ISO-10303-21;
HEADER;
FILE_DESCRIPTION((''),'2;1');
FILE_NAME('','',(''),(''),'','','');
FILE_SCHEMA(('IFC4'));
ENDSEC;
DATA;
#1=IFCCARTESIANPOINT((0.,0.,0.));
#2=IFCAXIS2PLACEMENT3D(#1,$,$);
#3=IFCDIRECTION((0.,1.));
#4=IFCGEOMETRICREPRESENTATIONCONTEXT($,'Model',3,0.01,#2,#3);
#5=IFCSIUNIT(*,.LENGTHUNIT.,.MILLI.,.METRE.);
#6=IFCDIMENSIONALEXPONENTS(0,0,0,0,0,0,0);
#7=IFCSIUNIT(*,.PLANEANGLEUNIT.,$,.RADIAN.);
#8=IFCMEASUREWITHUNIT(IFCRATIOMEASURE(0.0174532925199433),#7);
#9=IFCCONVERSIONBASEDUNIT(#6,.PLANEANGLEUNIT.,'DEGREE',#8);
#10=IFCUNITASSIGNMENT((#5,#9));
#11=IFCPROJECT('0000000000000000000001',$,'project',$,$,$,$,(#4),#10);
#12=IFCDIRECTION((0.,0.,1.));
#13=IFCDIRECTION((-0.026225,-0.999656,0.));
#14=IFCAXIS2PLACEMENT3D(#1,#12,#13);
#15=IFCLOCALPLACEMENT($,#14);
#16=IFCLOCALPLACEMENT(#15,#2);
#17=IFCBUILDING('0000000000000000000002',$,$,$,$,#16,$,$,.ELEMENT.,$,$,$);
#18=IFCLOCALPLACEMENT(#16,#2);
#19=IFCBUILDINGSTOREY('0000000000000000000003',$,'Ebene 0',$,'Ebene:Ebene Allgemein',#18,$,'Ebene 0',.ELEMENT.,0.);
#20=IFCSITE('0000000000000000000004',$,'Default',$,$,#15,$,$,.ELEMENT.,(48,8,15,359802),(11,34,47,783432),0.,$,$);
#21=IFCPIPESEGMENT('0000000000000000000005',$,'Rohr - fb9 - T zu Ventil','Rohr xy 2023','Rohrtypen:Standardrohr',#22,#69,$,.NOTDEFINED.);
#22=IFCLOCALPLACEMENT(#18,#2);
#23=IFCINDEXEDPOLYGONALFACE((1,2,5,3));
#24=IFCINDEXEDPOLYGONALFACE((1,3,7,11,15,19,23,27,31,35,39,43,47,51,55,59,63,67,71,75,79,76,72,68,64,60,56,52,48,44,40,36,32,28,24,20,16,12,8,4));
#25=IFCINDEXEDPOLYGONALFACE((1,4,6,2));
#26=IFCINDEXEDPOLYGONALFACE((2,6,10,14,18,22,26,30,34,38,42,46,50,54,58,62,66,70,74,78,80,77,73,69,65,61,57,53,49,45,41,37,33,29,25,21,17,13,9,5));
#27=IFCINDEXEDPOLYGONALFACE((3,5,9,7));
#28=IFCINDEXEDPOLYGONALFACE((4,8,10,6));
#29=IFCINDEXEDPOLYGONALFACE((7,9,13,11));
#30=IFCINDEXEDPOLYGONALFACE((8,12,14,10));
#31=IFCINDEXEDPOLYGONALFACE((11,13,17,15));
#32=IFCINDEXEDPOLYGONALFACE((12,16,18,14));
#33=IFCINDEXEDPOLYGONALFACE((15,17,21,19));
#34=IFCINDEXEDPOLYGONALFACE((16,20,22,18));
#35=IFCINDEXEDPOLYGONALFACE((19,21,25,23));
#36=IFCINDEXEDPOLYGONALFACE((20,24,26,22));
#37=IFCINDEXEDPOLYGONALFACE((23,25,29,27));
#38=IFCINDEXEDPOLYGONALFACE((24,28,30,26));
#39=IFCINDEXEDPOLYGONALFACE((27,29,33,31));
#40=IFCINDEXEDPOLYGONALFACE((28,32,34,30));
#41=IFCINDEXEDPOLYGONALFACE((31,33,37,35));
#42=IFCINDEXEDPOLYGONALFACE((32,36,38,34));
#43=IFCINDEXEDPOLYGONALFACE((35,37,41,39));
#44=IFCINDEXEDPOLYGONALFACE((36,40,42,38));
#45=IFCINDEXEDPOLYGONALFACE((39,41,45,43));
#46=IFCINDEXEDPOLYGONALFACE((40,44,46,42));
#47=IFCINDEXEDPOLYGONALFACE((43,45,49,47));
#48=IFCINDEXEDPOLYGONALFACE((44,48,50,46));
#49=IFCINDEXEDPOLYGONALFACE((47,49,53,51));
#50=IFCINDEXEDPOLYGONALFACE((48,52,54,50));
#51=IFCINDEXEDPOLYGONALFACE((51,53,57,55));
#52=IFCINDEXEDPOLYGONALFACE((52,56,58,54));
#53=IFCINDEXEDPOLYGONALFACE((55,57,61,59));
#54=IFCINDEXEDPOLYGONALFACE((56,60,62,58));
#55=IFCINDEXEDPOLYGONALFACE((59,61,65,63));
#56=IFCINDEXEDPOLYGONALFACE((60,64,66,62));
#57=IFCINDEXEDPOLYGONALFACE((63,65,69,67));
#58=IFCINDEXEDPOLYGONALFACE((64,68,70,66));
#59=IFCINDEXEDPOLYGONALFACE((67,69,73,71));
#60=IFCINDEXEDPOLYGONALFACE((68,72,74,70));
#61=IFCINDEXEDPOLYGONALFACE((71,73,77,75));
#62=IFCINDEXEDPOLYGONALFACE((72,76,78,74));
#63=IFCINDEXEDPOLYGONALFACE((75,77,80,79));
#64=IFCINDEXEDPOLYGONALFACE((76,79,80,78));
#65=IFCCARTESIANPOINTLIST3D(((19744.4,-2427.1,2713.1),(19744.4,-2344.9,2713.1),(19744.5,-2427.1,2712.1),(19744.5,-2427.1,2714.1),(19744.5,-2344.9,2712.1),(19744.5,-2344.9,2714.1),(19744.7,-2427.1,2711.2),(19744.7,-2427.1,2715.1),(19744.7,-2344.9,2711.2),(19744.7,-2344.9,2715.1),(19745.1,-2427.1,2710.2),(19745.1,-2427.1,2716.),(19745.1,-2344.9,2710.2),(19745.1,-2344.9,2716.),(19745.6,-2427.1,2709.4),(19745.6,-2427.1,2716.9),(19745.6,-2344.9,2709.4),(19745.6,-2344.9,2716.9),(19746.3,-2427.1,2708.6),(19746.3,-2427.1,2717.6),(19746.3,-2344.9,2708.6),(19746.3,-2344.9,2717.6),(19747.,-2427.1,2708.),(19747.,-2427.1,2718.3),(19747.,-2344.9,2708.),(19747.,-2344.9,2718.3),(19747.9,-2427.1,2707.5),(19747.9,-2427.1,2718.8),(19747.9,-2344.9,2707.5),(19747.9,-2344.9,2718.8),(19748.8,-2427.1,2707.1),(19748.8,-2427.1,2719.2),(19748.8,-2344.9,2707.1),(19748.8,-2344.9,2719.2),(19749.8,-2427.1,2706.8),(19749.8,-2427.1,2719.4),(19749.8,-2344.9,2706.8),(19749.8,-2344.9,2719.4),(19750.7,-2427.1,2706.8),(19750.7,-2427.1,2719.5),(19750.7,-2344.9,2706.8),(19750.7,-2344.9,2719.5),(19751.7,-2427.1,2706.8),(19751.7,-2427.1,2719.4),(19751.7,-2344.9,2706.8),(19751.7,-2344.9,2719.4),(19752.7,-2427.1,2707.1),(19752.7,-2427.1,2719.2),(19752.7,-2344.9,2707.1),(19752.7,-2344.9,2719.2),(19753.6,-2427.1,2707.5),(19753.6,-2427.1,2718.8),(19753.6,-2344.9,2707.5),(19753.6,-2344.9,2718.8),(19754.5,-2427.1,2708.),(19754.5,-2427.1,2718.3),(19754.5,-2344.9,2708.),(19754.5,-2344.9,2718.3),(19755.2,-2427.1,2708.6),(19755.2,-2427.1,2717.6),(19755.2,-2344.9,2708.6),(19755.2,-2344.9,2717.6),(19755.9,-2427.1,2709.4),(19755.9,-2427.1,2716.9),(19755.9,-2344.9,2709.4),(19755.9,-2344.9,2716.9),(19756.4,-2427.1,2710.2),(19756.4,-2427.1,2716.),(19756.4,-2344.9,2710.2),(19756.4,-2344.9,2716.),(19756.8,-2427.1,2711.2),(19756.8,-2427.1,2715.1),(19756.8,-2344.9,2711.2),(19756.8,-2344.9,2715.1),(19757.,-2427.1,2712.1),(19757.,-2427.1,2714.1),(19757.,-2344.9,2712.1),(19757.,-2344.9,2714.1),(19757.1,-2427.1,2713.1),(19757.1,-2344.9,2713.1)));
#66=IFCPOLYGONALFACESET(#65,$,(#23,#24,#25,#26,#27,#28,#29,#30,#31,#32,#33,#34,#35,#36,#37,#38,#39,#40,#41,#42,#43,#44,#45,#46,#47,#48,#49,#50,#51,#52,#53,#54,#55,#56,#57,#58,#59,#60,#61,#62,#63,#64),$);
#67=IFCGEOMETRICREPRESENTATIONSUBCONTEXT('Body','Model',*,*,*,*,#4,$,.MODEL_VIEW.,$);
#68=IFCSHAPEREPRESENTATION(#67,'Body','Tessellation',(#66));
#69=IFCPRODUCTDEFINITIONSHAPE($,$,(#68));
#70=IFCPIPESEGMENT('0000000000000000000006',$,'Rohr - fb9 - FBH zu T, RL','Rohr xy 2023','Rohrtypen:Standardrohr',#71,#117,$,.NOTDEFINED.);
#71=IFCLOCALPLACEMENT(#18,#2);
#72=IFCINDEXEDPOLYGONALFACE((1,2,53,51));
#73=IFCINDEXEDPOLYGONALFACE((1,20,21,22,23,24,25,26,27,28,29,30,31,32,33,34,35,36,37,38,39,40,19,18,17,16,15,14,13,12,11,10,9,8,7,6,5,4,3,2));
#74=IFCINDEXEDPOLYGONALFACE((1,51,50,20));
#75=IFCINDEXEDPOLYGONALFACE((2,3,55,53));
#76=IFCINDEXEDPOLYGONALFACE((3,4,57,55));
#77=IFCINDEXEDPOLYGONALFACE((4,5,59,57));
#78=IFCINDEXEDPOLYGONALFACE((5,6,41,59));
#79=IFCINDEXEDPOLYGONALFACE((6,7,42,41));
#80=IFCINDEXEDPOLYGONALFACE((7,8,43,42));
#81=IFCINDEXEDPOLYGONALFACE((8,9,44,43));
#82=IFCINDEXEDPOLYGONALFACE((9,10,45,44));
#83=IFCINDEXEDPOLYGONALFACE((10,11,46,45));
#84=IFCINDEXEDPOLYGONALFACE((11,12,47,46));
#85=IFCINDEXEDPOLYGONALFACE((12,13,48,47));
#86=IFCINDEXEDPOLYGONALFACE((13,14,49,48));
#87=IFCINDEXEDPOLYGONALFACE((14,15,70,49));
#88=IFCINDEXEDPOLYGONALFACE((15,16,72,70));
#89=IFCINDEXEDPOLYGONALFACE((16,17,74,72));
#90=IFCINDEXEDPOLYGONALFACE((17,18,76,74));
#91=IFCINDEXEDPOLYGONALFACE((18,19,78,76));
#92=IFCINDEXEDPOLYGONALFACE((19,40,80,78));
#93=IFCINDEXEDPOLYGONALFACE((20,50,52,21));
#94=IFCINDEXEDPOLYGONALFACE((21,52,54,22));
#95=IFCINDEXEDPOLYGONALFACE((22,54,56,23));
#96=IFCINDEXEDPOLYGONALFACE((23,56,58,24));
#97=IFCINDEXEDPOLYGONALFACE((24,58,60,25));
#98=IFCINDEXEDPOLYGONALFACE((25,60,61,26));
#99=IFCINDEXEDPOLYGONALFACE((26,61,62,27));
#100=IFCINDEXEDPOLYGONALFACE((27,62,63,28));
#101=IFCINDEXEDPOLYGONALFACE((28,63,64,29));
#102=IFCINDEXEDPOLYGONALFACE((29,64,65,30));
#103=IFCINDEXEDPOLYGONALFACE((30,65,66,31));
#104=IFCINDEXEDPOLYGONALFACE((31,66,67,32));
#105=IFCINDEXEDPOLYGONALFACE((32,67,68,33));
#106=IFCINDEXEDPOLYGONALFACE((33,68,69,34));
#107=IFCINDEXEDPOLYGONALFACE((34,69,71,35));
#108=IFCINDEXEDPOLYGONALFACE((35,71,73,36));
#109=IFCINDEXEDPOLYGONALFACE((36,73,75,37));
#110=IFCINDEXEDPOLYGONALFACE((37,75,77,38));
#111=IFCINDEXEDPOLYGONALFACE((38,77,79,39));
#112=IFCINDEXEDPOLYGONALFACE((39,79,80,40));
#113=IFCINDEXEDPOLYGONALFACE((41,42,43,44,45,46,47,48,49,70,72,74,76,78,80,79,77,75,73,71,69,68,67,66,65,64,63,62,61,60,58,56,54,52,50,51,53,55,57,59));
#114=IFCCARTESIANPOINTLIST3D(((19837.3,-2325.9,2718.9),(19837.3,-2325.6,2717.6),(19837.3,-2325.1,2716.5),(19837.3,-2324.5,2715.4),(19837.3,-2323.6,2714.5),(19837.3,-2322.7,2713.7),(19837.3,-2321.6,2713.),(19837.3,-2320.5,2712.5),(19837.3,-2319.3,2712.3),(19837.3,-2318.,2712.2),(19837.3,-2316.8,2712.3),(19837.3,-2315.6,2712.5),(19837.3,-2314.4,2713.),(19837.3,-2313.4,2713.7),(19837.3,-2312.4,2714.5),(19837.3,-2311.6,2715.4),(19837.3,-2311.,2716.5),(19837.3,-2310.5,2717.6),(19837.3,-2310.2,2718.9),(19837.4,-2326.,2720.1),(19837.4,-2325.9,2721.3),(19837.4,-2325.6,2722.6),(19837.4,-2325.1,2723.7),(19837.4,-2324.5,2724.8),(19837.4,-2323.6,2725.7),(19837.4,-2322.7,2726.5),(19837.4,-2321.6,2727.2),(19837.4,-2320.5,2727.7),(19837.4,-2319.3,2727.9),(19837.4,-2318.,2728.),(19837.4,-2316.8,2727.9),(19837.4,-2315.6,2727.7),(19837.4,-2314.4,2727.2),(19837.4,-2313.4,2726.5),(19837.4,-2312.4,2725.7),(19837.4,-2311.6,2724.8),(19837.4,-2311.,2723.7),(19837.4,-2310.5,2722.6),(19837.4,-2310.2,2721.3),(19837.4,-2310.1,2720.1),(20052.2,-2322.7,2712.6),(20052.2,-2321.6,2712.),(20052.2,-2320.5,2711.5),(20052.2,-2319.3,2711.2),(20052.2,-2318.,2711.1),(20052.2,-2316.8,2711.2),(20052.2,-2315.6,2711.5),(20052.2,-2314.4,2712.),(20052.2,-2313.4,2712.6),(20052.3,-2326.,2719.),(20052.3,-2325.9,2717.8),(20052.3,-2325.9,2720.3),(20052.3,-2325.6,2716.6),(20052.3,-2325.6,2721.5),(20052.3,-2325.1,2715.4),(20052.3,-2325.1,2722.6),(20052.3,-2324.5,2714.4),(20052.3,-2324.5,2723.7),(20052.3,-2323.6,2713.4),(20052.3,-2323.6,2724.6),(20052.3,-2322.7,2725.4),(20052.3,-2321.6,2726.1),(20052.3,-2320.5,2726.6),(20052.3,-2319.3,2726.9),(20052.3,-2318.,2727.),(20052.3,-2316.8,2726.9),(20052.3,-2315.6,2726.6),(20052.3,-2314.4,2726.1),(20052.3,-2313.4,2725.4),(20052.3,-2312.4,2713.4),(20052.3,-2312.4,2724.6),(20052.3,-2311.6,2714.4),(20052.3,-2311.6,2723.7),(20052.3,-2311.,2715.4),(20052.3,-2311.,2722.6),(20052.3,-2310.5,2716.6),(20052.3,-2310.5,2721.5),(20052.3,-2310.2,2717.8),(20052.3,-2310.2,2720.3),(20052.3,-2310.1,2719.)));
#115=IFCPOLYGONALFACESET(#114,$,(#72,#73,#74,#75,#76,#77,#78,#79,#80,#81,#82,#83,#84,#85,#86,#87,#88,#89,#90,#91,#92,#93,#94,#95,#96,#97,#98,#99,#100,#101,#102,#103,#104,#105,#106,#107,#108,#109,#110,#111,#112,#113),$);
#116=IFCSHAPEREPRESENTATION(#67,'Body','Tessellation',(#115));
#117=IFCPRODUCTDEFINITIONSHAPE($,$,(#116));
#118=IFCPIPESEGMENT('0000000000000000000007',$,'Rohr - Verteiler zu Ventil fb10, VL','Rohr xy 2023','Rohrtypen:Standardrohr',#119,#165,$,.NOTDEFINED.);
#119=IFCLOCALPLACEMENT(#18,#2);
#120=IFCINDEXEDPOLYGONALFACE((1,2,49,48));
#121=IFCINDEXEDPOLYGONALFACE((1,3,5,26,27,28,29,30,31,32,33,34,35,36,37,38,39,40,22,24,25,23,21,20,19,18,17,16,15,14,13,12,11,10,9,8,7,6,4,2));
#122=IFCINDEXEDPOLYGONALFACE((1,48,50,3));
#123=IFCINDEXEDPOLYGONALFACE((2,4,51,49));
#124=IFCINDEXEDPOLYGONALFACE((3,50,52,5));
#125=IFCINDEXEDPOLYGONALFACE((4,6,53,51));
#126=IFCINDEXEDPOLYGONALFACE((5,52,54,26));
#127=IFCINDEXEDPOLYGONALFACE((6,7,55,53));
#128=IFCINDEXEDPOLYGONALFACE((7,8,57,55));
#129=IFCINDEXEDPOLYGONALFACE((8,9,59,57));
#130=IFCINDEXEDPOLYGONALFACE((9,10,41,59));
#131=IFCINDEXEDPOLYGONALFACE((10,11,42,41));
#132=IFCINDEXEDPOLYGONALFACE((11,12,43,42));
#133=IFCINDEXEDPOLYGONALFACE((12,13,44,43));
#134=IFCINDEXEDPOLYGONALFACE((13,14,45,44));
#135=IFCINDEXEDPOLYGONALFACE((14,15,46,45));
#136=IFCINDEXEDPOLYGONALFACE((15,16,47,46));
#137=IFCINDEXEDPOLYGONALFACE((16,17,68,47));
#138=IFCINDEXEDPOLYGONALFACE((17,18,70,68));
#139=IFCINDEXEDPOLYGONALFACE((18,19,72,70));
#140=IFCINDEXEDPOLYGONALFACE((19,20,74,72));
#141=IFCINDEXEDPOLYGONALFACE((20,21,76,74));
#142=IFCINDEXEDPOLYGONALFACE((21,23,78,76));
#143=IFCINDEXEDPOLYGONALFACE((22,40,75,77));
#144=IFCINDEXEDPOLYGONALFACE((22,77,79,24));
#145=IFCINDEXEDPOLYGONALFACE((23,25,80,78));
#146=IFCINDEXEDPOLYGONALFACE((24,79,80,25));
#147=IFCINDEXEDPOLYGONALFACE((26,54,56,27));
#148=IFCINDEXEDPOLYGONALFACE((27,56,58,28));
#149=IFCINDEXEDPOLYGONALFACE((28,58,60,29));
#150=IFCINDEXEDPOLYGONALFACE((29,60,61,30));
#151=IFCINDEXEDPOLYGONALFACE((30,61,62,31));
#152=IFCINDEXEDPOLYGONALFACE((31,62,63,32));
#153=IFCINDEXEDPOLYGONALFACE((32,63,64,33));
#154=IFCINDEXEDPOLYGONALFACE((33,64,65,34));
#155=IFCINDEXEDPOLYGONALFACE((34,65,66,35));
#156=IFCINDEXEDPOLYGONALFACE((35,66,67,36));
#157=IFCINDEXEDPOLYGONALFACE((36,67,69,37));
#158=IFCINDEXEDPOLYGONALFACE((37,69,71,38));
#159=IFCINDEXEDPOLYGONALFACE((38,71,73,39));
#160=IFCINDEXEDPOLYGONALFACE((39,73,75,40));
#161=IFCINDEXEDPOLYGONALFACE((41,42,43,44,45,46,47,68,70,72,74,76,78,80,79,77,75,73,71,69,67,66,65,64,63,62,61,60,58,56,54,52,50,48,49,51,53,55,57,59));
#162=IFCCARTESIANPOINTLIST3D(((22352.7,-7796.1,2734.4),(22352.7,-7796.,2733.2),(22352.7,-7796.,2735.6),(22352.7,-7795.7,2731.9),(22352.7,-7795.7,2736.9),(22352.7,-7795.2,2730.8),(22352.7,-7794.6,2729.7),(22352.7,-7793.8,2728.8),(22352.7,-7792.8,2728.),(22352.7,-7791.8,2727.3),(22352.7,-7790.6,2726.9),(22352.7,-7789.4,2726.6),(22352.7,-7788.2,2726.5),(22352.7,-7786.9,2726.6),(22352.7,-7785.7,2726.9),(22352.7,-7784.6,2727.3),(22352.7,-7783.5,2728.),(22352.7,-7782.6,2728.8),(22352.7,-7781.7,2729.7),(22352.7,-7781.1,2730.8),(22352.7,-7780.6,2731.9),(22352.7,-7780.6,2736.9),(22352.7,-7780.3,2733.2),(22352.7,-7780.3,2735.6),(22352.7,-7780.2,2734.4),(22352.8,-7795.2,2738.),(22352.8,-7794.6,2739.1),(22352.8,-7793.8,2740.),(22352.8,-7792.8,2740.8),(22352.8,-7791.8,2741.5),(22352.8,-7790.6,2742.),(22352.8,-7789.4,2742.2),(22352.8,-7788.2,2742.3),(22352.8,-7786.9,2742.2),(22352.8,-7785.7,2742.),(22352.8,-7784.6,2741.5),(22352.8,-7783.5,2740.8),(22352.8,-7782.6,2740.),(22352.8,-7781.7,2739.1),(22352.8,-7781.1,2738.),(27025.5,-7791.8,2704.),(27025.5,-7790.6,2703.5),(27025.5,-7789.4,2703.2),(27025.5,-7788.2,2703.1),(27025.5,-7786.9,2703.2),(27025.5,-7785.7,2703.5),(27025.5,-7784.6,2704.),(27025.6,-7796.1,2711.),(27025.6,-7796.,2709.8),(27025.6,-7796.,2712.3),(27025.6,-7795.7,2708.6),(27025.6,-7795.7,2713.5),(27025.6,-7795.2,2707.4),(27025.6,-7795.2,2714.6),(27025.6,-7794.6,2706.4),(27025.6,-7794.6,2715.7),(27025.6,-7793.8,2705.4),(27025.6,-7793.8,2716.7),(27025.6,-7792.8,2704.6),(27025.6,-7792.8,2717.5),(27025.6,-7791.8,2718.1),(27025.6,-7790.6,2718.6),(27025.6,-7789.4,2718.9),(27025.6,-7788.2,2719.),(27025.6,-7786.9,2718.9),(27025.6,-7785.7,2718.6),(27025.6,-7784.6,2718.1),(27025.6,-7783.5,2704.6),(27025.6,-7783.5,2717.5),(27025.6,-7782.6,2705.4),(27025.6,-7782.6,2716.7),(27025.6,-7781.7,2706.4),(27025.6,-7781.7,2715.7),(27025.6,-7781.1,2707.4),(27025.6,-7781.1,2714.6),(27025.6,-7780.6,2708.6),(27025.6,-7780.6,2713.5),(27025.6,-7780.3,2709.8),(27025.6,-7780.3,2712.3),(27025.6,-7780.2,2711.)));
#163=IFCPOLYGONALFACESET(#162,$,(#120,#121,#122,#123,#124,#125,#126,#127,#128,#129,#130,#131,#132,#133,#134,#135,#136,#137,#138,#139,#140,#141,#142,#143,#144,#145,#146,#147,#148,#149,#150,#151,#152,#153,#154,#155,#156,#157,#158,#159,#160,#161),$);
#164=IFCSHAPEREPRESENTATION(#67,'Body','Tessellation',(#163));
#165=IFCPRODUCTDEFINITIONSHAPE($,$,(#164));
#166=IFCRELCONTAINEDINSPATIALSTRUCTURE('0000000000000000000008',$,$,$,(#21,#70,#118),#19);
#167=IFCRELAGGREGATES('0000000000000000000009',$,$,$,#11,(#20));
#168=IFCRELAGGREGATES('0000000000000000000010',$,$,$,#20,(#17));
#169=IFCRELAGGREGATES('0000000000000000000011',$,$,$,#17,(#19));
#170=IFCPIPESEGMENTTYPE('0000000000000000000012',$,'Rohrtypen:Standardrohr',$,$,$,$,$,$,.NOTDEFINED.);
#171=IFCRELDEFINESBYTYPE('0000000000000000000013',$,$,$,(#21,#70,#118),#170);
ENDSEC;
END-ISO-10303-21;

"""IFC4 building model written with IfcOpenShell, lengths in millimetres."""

from ifc_helpers import new_model, entity, si_unit, converted_unit, direction, frame, origin, place, context, subcontext, project, spatial, indexed_curve, outline, extrude, type_object, element, save


model = new_model("IFC4")

# Units and contexts
model_context = context("Model", 3, precision=0.01, world=origin(), true_north=direction((0.0, 1.0)))
body_context = subcontext(model_context, "Body", "Model", "MODEL_VIEW")
ifc_project = project(units=[si_unit("LENGTHUNIT", "METRE", prefix="MILLI"), converted_unit("PLANEANGLEUNIT", "DEGREE", entity("IfcRatioMeasure", 0.0174532925199433), si_unit("PLANEANGLEUNIT", "RADIAN"), dimensions=[0, 0, 0, 0, 0, 0, 0])], contexts=[model_context])

# Site, building, storey
site_placement = place(None, frame((0.0, 0.0, 0.0), z_axis=(0.0, 0.0, 1.0), x_axis=(-0.026225, -0.999656, 0.0)))
site = spatial("IfcSite", under=ifc_project, at=site_placement, Name="Default", CompositionType="ELEMENT", RefLatitude=(48, 8, 15, 359802), RefLongitude=(11, 34, 47, 783432), RefElevation=0.0)
building_placement = place(site_placement, origin())
building = spatial("IfcBuilding", under=site, at=building_placement, CompositionType="ELEMENT")
storey_placement = place(building_placement, origin())
storey = spatial("IfcBuildingStorey", under=building, at=storey_placement, Name="Ebene 0", ObjectType="Ebene:Ebene Allgemein", LongName="Ebene 0", CompositionType="ELEMENT", Elevation=0.0)

# Pipe segments
pipe_segment_type = type_object("IfcPipeSegmentType", Name="Rohrtypen:Standardrohr", PredefinedType="NOTDEFINED")
pipe_segment_1_placement = place(storey_placement, origin())
element("IfcPipeSegment", 1, at=pipe_segment_1_placement, inside=storey, type_object=pipe_segment_type, Name="Rohr - fb9 - T zu Ventil", Description="Rohr xy 2023", ObjectType="Rohrtypen:Standardrohr", PredefinedType="NOTDEFINED", context=body_context, shape_type="SweptSolid", body=[
    extrude(outline(indexed_curve([(6.3, 0.0), (6.3, 1.0), (6.0, 2.0), (5.7, 2.9), (5.1, 3.7), (4.5, 4.5), (3.7, 5.1), (2.9, 5.7), (2.0, 6.0), (1.0, 6.3), (0.0, 6.4), (-1.0, 6.3), (-2.0, 6.0), (-2.9, 5.7), (-3.7, 5.1), (-4.5, 4.5), (-5.1, 3.7), (-5.7, 2.9), (-6.0, 2.0), (-6.3, 1.0), (-6.3, 0.0), (-6.3, -1.0), (-6.0, -2.0), (-5.7, -2.9), (-5.1, -3.7), (-4.5, -4.5), (-3.7, -5.1), (-2.9, -5.7), (-2.0, -6.0), (-1.0, -6.3), (0.0, -6.4), (1.0, -6.3), (2.0, -6.0), (2.9, -5.7), (3.7, -5.1), (4.5, -4.5), (5.1, -3.7), (5.7, -2.9), (6.0, -2.0), (6.3, -1.0), (6.3, 0.0)], self_intersect=False)), frame((19750.7, -2427.1, 2713.1), z_axis=(0.0, 1.0, 0.0), x_axis=(-1.0, 0.0, 0.0)), (0.0, 0.0, 1.0), 82.2),
])
pipe_segment_2_placement = place(storey_placement, origin())
element("IfcPipeSegment", 2, at=pipe_segment_2_placement, inside=storey, type_object=pipe_segment_type, Name="Rohr - fb9 - FBH zu T, RL", Description="Rohr xy 2023", ObjectType="Rohrtypen:Standardrohr", PredefinedType="NOTDEFINED", context=body_context, shape_type="SweptSolid", body=[
    extrude(outline(indexed_curve([(7.9, 0.0), (7.8, 1.2), (7.6, 2.5), (7.1, 3.6), (6.4, 4.7), (5.6, 5.6), (4.7, 6.4), (3.6, 7.1), (2.5, 7.6), (1.2, 7.8), (0.0, 7.9), (-1.2, 7.8), (-2.5, 7.6), (-3.6, 7.1), (-4.7, 6.4), (-5.6, 5.6), (-6.4, 4.7), (-7.1, 3.6), (-7.6, 2.5), (-7.8, 1.2), (-7.9, 0.0), (-7.8, -1.2), (-7.6, -2.5), (-7.1, -3.6), (-6.4, -4.7), (-5.6, -5.6), (-4.7, -6.4), (-3.6, -7.1), (-2.5, -7.6), (-1.2, -7.8), (0.0, -7.9), (1.2, -7.8), (2.5, -7.6), (3.6, -7.1), (4.7, -6.4), (5.6, -5.6), (6.4, -4.7), (7.1, -3.6), (7.6, -2.5), (7.8, -1.2), (7.9, 0.0)], self_intersect=False)), frame((20052.3, -2318.0, 2719.0), z_axis=(-0.999988, 0.0, 0.005), x_axis=(0.0, 1.0, 0.0)), (0.0, 0.0, 1.0), 214.9),
])
pipe_segment_3_placement = place(storey_placement, origin())
element("IfcPipeSegment", 3, at=pipe_segment_3_placement, inside=storey, type_object=pipe_segment_type, Name="Rohr - Verteiler zu Ventil fb10, VL", Description="Rohr xy 2023", ObjectType="Rohrtypen:Standardrohr", PredefinedType="NOTDEFINED", context=body_context, shape_type="SweptSolid", body=[
    extrude(outline(indexed_curve([(7.9, 0.0), (7.8, 1.2), (7.6, 2.5), (7.1, 3.6), (6.4, 4.7), (5.6, 5.6), (4.7, 6.4), (3.6, 7.1), (2.5, 7.6), (1.2, 7.8), (0.0, 7.9), (-1.2, 7.8), (-2.5, 7.6), (-3.6, 7.1), (-4.7, 6.4), (-5.6, 5.6), (-6.4, 4.7), (-7.1, 3.6), (-7.6, 2.5), (-7.8, 1.2), (-7.9, 0.0), (-7.8, -1.2), (-7.6, -2.5), (-7.1, -3.6), (-6.4, -4.7), (-5.6, -5.6), (-4.7, -6.4), (-3.6, -7.1), (-2.5, -7.6), (-1.2, -7.8), (0.0, -7.9), (1.2, -7.8), (2.5, -7.6), (3.6, -7.1), (4.7, -6.4), (5.6, -5.6), (6.4, -4.7), (7.1, -3.6), (7.6, -2.5), (7.8, -1.2), (7.9, 0.0)], self_intersect=False)), frame((27025.6, -7788.2, 2711.0), z_axis=(-0.999988, 0.0, 0.005), x_axis=(0.0, 1.0, 0.0)), (0.0, 0.0, 1.0), 4672.9),
])

save(model, "model.ifc")
